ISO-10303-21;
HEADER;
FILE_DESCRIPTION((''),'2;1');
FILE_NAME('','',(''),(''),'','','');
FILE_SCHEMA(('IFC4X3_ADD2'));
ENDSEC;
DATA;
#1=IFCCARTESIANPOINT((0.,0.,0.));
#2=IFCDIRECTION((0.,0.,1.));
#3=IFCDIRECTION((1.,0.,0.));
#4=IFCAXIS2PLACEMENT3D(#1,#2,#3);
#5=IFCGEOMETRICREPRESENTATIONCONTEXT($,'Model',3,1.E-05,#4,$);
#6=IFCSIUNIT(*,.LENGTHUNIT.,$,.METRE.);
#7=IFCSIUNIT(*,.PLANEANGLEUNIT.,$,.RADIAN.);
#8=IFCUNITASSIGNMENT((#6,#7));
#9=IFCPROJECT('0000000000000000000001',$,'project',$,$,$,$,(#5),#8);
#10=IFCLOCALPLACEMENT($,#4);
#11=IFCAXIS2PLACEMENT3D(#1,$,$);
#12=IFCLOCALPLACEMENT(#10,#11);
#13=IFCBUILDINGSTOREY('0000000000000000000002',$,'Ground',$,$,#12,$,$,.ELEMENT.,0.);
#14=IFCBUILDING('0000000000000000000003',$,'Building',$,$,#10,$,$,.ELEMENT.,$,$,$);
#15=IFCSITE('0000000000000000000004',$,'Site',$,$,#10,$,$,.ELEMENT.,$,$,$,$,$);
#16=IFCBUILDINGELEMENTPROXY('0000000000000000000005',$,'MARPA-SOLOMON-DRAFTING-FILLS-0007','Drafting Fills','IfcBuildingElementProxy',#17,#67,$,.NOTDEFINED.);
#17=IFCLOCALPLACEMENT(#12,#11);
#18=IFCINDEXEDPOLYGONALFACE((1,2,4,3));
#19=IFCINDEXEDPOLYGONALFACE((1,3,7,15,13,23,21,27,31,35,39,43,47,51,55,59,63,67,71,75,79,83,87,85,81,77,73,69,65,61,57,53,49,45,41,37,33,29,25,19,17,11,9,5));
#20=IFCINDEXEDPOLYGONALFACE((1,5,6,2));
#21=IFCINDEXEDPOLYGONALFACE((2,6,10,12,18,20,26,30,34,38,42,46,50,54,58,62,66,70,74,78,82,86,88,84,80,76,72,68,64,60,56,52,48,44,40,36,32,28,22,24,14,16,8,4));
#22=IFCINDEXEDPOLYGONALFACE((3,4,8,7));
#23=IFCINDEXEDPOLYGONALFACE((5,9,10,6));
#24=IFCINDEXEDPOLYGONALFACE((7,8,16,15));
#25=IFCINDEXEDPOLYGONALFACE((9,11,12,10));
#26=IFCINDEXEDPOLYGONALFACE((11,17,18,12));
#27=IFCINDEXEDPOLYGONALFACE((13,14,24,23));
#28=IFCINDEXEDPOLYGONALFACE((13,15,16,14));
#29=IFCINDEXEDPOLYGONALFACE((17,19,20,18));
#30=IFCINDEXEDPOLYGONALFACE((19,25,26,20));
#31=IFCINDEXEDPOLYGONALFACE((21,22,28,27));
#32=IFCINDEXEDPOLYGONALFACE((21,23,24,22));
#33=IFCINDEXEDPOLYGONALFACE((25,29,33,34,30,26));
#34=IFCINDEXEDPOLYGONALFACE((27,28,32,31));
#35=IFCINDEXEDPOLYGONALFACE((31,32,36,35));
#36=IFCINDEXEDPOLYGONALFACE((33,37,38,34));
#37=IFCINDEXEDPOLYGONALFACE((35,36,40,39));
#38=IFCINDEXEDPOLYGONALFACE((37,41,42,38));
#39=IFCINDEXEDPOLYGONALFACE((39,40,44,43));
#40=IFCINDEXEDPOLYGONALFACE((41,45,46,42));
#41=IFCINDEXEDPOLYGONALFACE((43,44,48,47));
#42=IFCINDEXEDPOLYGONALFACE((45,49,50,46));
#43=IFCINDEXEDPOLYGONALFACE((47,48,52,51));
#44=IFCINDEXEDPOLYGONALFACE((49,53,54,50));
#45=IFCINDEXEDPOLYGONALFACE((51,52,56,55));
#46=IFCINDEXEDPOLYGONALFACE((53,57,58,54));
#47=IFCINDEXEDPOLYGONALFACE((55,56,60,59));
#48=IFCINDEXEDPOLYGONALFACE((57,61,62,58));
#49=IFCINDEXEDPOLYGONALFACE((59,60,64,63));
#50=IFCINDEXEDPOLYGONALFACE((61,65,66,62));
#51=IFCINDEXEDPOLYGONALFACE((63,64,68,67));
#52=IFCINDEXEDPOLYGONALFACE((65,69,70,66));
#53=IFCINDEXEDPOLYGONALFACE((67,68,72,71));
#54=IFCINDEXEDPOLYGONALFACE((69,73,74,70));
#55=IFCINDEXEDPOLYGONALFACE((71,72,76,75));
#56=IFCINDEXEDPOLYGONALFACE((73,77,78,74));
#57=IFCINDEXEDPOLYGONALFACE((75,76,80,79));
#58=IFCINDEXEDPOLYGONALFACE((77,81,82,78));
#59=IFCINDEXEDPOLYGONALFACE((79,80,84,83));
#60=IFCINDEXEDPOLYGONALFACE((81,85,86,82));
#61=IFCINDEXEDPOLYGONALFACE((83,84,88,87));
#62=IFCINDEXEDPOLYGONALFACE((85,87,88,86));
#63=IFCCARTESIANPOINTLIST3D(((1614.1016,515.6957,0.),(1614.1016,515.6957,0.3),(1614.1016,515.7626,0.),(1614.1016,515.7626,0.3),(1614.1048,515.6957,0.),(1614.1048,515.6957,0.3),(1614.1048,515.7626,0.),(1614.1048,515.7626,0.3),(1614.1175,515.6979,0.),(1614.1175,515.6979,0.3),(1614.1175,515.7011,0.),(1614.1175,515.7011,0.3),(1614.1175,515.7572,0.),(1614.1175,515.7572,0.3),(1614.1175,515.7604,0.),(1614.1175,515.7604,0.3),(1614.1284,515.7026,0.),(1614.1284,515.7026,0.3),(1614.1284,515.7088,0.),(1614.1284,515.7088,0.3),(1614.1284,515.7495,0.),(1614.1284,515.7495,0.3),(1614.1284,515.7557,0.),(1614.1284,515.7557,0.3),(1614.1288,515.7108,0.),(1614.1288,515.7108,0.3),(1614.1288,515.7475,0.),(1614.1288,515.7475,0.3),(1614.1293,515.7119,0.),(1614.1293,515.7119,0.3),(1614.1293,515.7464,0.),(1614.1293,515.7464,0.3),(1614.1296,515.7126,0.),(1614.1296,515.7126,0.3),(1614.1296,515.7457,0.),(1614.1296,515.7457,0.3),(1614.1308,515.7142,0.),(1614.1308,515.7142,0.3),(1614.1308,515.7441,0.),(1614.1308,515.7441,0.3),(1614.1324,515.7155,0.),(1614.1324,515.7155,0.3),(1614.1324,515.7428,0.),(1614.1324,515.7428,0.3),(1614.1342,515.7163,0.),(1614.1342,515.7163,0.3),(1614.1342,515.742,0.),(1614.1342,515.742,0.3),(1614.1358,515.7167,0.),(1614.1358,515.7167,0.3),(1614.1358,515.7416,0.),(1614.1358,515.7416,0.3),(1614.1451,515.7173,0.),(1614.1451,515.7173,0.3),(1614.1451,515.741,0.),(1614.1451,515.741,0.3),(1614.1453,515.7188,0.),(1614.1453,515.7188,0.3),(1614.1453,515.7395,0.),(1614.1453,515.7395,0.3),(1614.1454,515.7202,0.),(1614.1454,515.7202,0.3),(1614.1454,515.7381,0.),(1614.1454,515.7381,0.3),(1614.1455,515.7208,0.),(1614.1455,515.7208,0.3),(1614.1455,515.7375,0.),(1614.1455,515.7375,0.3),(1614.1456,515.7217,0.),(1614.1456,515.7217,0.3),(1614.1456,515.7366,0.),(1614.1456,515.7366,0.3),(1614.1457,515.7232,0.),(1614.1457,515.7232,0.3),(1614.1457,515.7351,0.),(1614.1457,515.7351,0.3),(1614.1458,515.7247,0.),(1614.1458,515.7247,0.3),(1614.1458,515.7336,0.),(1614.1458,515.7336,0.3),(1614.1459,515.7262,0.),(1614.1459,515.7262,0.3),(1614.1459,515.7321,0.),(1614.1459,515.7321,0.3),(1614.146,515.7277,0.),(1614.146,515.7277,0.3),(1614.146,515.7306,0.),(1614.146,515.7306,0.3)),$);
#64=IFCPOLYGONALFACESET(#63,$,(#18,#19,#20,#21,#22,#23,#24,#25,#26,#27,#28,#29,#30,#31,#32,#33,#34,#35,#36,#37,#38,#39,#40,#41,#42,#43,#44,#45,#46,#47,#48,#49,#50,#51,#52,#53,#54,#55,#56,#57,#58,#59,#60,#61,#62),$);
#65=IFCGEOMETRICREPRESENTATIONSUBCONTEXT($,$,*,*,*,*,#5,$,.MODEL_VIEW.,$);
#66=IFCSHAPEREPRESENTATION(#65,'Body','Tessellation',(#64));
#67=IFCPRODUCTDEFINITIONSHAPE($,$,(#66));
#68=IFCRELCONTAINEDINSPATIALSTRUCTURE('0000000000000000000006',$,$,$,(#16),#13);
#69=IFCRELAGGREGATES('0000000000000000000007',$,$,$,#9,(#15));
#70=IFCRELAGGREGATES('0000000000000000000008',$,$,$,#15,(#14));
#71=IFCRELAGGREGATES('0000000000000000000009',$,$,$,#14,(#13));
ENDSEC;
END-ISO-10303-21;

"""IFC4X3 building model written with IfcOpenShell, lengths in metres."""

from ifc_helpers import new_model, si_unit, frame, origin, origin_with_axes, place, context, subcontext, project, spatial, polyline, outline, extrude, element, save


model = new_model("IFC4X3")

# Units and contexts
model_context = context("Model", 3, precision=1e-05, world=origin_with_axes())
sub_context = subcontext(model_context, None, None, "MODEL_VIEW")
ifc_project = project(units=[si_unit("LENGTHUNIT", "METRE"), si_unit("PLANEANGLEUNIT", "RADIAN")], contexts=[model_context])

# Site, building, storey
placement = place(None, origin_with_axes())
site = spatial("IfcSite", under=ifc_project, at=placement, Name="Site", CompositionType="ELEMENT")
building = spatial("IfcBuilding", under=site, at=placement, Name="Building", CompositionType="ELEMENT")
storey_placement = place(placement, origin())
storey = spatial("IfcBuildingStorey", under=building, at=storey_placement, Name="Ground", CompositionType="ELEMENT", Elevation=0.0)

# Building element proxy
proxy_1_placement = place(placement, frame((1614.1016, 515.6957, 0.0)))
element("IfcBuildingElementProxy", 1, at=proxy_1_placement, inside=storey, Name="MARPA-SOLOMON-DRAFTING-FILLS-0007", Description="Drafting Fills", ObjectType="IfcBuildingElementProxy", PredefinedType="NOTDEFINED", context=sub_context, shape_type="SweptSolid", body=[
    extrude(outline(polyline([(0.0159, 0.0022), (0.0159, 0.0054), (0.0268, 0.007), (0.0268, 0.0131), (0.0272, 0.0151), (0.0277, 0.0162), (0.028, 0.017), (0.0292, 0.0186), (0.0308, 0.0198), (0.0326, 0.0207), (0.0342, 0.021), (0.0435, 0.0216), (0.0437, 0.0231), (0.0439, 0.0246), (0.0439, 0.0251), (0.044, 0.0261), (0.0441, 0.0275), (0.0443, 0.029), (0.0443, 0.0305), (0.0445, 0.032), (0.0445, 0.035), (0.0443, 0.0365), (0.0442, 0.0379), (0.0441, 0.0394), (0.044, 0.0409), (0.0439, 0.0419), (0.0439, 0.0424), (0.0437, 0.0439), (0.0435, 0.0453), (0.0342, 0.046), (0.0326, 0.0463), (0.0308, 0.0471), (0.0292, 0.0484), (0.028, 0.05), (0.0277, 0.0507), (0.0272, 0.0519), (0.0268, 0.0538), (0.0268, 0.06), (0.0159, 0.0616), (0.0159, 0.0647), (0.0032, 0.067), (0.0, 0.067), (0.0, 0.0), (0.0032, 0.0), (0.0159, 0.0022)])), origin(), (0.0, 0.0, 1.0), 0.3),
])

save(model, "model.ifc")
